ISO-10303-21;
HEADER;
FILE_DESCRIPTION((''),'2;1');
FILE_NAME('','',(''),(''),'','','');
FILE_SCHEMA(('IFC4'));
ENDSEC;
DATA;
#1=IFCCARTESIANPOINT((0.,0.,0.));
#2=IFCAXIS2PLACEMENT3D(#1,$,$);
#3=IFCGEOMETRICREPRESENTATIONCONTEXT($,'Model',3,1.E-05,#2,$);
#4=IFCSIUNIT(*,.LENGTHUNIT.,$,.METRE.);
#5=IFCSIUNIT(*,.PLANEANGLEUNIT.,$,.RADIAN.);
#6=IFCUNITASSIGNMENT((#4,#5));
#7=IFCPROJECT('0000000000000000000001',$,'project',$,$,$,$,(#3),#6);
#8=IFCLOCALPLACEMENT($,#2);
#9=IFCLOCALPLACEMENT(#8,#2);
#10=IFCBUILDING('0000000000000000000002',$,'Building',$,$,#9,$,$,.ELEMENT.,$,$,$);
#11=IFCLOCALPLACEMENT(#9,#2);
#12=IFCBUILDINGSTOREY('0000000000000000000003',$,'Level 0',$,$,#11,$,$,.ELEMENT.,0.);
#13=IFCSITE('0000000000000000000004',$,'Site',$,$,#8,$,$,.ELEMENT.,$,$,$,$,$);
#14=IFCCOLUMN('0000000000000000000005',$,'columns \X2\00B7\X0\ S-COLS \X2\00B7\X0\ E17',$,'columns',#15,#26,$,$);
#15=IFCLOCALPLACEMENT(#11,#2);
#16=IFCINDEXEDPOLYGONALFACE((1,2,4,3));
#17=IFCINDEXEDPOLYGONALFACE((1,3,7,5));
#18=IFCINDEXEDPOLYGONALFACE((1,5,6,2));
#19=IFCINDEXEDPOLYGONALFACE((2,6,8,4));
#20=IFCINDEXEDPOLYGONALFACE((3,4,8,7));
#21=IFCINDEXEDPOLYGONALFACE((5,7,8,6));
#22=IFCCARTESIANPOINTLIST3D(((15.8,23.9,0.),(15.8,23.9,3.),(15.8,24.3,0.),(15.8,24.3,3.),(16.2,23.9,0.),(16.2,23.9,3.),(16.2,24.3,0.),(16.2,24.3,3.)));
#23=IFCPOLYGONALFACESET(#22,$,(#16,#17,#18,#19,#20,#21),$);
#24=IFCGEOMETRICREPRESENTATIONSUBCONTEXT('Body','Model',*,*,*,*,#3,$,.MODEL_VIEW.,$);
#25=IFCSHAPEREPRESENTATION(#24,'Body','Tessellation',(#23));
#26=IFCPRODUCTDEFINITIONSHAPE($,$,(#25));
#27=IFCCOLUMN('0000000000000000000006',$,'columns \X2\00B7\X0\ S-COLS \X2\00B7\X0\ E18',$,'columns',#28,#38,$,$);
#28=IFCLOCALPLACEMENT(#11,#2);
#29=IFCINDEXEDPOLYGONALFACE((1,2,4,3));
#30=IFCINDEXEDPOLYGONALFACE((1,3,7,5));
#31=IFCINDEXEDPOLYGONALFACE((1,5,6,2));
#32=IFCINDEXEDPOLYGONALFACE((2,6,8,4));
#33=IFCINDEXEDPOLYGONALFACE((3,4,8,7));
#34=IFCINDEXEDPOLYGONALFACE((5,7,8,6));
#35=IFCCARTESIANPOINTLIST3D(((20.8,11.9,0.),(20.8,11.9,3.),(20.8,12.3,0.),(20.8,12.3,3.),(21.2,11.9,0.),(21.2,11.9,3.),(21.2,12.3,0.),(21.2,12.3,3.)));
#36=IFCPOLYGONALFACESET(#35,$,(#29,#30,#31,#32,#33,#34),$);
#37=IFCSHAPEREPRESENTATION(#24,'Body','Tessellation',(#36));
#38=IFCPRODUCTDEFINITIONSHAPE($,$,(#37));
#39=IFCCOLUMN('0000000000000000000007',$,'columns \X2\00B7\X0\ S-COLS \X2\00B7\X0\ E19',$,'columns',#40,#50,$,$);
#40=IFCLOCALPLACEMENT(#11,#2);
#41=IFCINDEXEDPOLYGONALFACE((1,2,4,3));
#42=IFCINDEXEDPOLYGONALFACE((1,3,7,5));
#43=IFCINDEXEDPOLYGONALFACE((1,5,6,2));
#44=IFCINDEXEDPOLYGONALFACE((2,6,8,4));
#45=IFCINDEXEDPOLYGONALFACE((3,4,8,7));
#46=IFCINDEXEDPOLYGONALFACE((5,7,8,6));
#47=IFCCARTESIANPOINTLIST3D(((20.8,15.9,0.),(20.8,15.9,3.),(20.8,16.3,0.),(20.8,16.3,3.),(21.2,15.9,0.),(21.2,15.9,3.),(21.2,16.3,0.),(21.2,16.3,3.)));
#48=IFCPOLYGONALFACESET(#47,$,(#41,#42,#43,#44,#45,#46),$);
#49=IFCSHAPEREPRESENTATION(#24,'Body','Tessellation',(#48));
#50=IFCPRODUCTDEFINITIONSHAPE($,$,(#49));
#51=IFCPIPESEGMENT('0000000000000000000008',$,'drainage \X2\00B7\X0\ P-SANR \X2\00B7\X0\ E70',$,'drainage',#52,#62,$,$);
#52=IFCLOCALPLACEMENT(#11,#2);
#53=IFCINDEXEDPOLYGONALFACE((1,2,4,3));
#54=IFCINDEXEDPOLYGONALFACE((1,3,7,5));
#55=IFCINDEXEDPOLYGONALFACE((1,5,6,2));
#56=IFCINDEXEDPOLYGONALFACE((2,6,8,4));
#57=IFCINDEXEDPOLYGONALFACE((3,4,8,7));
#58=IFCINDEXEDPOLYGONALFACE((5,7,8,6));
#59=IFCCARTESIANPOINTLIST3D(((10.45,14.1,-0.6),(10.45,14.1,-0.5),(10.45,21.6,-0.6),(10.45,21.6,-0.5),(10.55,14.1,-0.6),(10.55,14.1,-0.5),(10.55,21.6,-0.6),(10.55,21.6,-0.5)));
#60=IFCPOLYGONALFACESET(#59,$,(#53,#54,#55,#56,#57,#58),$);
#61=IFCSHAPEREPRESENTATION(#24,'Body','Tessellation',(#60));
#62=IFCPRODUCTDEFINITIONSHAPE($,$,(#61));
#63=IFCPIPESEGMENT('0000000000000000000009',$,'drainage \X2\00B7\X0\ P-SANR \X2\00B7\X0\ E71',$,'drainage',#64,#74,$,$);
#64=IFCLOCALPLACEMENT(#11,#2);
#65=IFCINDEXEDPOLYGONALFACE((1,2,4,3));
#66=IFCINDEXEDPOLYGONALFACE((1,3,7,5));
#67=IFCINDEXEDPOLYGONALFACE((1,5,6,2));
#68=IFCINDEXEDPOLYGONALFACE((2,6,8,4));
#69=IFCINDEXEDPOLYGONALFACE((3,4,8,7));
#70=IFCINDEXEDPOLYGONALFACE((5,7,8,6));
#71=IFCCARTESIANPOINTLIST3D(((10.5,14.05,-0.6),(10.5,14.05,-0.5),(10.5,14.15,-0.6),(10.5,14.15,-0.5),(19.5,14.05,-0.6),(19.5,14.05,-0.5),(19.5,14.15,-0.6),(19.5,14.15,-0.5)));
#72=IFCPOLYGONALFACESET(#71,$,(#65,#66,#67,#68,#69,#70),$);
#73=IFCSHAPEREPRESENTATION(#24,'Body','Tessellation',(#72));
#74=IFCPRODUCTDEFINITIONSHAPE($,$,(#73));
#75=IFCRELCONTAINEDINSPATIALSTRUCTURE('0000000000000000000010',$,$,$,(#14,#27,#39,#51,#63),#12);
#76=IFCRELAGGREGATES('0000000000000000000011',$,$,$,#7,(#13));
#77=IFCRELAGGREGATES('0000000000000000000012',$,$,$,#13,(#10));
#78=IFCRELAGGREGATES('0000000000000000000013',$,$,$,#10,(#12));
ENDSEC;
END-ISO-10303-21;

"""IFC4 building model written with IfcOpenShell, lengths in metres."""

from ifc_helpers import new_model, si_unit, frame, origin, place, context, subcontext, project, spatial, polyline, outline, extrude, element, save


model = new_model("IFC4")

# Units and contexts
model_context = context("Model", 3, precision=1e-05, world=origin())
body_context = subcontext(model_context, "Body", "Model", "MODEL_VIEW")
ifc_project = project(units=[si_unit("LENGTHUNIT", "METRE"), si_unit("PLANEANGLEUNIT", "RADIAN")], contexts=[model_context])

# Site, building, storey
site_placement = place(None, origin())
site = spatial("IfcSite", under=ifc_project, at=site_placement, Name="Site", CompositionType="ELEMENT")
building_placement = place(site_placement, origin())
building = spatial("IfcBuilding", under=site, at=building_placement, Name="Building", CompositionType="ELEMENT")
storey_placement = place(building_placement, origin())
storey = spatial("IfcBuildingStorey", under=building, at=storey_placement, Name="Level 0", CompositionType="ELEMENT", Elevation=0.0)

# Columns
column_1_placement = place(storey_placement, origin())
element("IfcColumn", 1, at=column_1_placement, inside=storey, Name="columns · S-COLS · E17", ObjectType="columns", context=body_context, shape_type="SweptSolid", body=[
    extrude(outline(polyline([(15.8, 23.9), (16.2, 23.9), (16.2, 24.3), (15.8, 24.3), (15.8, 23.9)])), origin(), (0.0, 0.0, 1.0), 3.0),
])
column_2_placement = place(storey_placement, origin())
element("IfcColumn", 2, at=column_2_placement, inside=storey, Name="columns · S-COLS · E18", ObjectType="columns", context=body_context, shape_type="SweptSolid", body=[
    extrude(outline(polyline([(20.8, 11.9), (21.2, 11.9), (21.2, 12.3), (20.8, 12.3), (20.8, 11.9)])), origin(), (0.0, 0.0, 1.0), 3.0),
])
column_3_placement = place(storey_placement, origin())
element("IfcColumn", 3, at=column_3_placement, inside=storey, Name="columns · S-COLS · E19", ObjectType="columns", context=body_context, shape_type="SweptSolid", body=[
    extrude(outline(polyline([(20.8, 15.9), (21.2, 15.9), (21.2, 16.3), (20.8, 16.3), (20.8, 15.9)])), origin(), (0.0, 0.0, 1.0), 3.0),
])

# Pipe segments
pipe_segment_1_placement = place(storey_placement, frame((0.0, 0.0, -0.6)))
element("IfcPipeSegment", 4, at=pipe_segment_1_placement, inside=storey, Name="drainage · P-SANR · E70", ObjectType="drainage", context=body_context, shape_type="SweptSolid", body=[
    extrude(outline(polyline([(10.45, 21.6), (10.45, 14.1), (10.55, 14.1), (10.55, 21.6), (10.45, 21.6)])), origin(), (0.0, 0.0, 1.0), 0.1),
])
pipe_segment_2_placement = place(storey_placement, frame((0.0, 0.0, -0.6)))
element("IfcPipeSegment", 5, at=pipe_segment_2_placement, inside=storey, Name="drainage · P-SANR · E71", ObjectType="drainage", context=body_context, shape_type="SweptSolid", body=[
    extrude(outline(polyline([(10.5, 14.05), (19.5, 14.05), (19.5, 14.15), (10.5, 14.15), (10.5, 14.05)])), origin(), (0.0, 0.0, 1.0), 0.1),
])

save(model, "model.ifc")
